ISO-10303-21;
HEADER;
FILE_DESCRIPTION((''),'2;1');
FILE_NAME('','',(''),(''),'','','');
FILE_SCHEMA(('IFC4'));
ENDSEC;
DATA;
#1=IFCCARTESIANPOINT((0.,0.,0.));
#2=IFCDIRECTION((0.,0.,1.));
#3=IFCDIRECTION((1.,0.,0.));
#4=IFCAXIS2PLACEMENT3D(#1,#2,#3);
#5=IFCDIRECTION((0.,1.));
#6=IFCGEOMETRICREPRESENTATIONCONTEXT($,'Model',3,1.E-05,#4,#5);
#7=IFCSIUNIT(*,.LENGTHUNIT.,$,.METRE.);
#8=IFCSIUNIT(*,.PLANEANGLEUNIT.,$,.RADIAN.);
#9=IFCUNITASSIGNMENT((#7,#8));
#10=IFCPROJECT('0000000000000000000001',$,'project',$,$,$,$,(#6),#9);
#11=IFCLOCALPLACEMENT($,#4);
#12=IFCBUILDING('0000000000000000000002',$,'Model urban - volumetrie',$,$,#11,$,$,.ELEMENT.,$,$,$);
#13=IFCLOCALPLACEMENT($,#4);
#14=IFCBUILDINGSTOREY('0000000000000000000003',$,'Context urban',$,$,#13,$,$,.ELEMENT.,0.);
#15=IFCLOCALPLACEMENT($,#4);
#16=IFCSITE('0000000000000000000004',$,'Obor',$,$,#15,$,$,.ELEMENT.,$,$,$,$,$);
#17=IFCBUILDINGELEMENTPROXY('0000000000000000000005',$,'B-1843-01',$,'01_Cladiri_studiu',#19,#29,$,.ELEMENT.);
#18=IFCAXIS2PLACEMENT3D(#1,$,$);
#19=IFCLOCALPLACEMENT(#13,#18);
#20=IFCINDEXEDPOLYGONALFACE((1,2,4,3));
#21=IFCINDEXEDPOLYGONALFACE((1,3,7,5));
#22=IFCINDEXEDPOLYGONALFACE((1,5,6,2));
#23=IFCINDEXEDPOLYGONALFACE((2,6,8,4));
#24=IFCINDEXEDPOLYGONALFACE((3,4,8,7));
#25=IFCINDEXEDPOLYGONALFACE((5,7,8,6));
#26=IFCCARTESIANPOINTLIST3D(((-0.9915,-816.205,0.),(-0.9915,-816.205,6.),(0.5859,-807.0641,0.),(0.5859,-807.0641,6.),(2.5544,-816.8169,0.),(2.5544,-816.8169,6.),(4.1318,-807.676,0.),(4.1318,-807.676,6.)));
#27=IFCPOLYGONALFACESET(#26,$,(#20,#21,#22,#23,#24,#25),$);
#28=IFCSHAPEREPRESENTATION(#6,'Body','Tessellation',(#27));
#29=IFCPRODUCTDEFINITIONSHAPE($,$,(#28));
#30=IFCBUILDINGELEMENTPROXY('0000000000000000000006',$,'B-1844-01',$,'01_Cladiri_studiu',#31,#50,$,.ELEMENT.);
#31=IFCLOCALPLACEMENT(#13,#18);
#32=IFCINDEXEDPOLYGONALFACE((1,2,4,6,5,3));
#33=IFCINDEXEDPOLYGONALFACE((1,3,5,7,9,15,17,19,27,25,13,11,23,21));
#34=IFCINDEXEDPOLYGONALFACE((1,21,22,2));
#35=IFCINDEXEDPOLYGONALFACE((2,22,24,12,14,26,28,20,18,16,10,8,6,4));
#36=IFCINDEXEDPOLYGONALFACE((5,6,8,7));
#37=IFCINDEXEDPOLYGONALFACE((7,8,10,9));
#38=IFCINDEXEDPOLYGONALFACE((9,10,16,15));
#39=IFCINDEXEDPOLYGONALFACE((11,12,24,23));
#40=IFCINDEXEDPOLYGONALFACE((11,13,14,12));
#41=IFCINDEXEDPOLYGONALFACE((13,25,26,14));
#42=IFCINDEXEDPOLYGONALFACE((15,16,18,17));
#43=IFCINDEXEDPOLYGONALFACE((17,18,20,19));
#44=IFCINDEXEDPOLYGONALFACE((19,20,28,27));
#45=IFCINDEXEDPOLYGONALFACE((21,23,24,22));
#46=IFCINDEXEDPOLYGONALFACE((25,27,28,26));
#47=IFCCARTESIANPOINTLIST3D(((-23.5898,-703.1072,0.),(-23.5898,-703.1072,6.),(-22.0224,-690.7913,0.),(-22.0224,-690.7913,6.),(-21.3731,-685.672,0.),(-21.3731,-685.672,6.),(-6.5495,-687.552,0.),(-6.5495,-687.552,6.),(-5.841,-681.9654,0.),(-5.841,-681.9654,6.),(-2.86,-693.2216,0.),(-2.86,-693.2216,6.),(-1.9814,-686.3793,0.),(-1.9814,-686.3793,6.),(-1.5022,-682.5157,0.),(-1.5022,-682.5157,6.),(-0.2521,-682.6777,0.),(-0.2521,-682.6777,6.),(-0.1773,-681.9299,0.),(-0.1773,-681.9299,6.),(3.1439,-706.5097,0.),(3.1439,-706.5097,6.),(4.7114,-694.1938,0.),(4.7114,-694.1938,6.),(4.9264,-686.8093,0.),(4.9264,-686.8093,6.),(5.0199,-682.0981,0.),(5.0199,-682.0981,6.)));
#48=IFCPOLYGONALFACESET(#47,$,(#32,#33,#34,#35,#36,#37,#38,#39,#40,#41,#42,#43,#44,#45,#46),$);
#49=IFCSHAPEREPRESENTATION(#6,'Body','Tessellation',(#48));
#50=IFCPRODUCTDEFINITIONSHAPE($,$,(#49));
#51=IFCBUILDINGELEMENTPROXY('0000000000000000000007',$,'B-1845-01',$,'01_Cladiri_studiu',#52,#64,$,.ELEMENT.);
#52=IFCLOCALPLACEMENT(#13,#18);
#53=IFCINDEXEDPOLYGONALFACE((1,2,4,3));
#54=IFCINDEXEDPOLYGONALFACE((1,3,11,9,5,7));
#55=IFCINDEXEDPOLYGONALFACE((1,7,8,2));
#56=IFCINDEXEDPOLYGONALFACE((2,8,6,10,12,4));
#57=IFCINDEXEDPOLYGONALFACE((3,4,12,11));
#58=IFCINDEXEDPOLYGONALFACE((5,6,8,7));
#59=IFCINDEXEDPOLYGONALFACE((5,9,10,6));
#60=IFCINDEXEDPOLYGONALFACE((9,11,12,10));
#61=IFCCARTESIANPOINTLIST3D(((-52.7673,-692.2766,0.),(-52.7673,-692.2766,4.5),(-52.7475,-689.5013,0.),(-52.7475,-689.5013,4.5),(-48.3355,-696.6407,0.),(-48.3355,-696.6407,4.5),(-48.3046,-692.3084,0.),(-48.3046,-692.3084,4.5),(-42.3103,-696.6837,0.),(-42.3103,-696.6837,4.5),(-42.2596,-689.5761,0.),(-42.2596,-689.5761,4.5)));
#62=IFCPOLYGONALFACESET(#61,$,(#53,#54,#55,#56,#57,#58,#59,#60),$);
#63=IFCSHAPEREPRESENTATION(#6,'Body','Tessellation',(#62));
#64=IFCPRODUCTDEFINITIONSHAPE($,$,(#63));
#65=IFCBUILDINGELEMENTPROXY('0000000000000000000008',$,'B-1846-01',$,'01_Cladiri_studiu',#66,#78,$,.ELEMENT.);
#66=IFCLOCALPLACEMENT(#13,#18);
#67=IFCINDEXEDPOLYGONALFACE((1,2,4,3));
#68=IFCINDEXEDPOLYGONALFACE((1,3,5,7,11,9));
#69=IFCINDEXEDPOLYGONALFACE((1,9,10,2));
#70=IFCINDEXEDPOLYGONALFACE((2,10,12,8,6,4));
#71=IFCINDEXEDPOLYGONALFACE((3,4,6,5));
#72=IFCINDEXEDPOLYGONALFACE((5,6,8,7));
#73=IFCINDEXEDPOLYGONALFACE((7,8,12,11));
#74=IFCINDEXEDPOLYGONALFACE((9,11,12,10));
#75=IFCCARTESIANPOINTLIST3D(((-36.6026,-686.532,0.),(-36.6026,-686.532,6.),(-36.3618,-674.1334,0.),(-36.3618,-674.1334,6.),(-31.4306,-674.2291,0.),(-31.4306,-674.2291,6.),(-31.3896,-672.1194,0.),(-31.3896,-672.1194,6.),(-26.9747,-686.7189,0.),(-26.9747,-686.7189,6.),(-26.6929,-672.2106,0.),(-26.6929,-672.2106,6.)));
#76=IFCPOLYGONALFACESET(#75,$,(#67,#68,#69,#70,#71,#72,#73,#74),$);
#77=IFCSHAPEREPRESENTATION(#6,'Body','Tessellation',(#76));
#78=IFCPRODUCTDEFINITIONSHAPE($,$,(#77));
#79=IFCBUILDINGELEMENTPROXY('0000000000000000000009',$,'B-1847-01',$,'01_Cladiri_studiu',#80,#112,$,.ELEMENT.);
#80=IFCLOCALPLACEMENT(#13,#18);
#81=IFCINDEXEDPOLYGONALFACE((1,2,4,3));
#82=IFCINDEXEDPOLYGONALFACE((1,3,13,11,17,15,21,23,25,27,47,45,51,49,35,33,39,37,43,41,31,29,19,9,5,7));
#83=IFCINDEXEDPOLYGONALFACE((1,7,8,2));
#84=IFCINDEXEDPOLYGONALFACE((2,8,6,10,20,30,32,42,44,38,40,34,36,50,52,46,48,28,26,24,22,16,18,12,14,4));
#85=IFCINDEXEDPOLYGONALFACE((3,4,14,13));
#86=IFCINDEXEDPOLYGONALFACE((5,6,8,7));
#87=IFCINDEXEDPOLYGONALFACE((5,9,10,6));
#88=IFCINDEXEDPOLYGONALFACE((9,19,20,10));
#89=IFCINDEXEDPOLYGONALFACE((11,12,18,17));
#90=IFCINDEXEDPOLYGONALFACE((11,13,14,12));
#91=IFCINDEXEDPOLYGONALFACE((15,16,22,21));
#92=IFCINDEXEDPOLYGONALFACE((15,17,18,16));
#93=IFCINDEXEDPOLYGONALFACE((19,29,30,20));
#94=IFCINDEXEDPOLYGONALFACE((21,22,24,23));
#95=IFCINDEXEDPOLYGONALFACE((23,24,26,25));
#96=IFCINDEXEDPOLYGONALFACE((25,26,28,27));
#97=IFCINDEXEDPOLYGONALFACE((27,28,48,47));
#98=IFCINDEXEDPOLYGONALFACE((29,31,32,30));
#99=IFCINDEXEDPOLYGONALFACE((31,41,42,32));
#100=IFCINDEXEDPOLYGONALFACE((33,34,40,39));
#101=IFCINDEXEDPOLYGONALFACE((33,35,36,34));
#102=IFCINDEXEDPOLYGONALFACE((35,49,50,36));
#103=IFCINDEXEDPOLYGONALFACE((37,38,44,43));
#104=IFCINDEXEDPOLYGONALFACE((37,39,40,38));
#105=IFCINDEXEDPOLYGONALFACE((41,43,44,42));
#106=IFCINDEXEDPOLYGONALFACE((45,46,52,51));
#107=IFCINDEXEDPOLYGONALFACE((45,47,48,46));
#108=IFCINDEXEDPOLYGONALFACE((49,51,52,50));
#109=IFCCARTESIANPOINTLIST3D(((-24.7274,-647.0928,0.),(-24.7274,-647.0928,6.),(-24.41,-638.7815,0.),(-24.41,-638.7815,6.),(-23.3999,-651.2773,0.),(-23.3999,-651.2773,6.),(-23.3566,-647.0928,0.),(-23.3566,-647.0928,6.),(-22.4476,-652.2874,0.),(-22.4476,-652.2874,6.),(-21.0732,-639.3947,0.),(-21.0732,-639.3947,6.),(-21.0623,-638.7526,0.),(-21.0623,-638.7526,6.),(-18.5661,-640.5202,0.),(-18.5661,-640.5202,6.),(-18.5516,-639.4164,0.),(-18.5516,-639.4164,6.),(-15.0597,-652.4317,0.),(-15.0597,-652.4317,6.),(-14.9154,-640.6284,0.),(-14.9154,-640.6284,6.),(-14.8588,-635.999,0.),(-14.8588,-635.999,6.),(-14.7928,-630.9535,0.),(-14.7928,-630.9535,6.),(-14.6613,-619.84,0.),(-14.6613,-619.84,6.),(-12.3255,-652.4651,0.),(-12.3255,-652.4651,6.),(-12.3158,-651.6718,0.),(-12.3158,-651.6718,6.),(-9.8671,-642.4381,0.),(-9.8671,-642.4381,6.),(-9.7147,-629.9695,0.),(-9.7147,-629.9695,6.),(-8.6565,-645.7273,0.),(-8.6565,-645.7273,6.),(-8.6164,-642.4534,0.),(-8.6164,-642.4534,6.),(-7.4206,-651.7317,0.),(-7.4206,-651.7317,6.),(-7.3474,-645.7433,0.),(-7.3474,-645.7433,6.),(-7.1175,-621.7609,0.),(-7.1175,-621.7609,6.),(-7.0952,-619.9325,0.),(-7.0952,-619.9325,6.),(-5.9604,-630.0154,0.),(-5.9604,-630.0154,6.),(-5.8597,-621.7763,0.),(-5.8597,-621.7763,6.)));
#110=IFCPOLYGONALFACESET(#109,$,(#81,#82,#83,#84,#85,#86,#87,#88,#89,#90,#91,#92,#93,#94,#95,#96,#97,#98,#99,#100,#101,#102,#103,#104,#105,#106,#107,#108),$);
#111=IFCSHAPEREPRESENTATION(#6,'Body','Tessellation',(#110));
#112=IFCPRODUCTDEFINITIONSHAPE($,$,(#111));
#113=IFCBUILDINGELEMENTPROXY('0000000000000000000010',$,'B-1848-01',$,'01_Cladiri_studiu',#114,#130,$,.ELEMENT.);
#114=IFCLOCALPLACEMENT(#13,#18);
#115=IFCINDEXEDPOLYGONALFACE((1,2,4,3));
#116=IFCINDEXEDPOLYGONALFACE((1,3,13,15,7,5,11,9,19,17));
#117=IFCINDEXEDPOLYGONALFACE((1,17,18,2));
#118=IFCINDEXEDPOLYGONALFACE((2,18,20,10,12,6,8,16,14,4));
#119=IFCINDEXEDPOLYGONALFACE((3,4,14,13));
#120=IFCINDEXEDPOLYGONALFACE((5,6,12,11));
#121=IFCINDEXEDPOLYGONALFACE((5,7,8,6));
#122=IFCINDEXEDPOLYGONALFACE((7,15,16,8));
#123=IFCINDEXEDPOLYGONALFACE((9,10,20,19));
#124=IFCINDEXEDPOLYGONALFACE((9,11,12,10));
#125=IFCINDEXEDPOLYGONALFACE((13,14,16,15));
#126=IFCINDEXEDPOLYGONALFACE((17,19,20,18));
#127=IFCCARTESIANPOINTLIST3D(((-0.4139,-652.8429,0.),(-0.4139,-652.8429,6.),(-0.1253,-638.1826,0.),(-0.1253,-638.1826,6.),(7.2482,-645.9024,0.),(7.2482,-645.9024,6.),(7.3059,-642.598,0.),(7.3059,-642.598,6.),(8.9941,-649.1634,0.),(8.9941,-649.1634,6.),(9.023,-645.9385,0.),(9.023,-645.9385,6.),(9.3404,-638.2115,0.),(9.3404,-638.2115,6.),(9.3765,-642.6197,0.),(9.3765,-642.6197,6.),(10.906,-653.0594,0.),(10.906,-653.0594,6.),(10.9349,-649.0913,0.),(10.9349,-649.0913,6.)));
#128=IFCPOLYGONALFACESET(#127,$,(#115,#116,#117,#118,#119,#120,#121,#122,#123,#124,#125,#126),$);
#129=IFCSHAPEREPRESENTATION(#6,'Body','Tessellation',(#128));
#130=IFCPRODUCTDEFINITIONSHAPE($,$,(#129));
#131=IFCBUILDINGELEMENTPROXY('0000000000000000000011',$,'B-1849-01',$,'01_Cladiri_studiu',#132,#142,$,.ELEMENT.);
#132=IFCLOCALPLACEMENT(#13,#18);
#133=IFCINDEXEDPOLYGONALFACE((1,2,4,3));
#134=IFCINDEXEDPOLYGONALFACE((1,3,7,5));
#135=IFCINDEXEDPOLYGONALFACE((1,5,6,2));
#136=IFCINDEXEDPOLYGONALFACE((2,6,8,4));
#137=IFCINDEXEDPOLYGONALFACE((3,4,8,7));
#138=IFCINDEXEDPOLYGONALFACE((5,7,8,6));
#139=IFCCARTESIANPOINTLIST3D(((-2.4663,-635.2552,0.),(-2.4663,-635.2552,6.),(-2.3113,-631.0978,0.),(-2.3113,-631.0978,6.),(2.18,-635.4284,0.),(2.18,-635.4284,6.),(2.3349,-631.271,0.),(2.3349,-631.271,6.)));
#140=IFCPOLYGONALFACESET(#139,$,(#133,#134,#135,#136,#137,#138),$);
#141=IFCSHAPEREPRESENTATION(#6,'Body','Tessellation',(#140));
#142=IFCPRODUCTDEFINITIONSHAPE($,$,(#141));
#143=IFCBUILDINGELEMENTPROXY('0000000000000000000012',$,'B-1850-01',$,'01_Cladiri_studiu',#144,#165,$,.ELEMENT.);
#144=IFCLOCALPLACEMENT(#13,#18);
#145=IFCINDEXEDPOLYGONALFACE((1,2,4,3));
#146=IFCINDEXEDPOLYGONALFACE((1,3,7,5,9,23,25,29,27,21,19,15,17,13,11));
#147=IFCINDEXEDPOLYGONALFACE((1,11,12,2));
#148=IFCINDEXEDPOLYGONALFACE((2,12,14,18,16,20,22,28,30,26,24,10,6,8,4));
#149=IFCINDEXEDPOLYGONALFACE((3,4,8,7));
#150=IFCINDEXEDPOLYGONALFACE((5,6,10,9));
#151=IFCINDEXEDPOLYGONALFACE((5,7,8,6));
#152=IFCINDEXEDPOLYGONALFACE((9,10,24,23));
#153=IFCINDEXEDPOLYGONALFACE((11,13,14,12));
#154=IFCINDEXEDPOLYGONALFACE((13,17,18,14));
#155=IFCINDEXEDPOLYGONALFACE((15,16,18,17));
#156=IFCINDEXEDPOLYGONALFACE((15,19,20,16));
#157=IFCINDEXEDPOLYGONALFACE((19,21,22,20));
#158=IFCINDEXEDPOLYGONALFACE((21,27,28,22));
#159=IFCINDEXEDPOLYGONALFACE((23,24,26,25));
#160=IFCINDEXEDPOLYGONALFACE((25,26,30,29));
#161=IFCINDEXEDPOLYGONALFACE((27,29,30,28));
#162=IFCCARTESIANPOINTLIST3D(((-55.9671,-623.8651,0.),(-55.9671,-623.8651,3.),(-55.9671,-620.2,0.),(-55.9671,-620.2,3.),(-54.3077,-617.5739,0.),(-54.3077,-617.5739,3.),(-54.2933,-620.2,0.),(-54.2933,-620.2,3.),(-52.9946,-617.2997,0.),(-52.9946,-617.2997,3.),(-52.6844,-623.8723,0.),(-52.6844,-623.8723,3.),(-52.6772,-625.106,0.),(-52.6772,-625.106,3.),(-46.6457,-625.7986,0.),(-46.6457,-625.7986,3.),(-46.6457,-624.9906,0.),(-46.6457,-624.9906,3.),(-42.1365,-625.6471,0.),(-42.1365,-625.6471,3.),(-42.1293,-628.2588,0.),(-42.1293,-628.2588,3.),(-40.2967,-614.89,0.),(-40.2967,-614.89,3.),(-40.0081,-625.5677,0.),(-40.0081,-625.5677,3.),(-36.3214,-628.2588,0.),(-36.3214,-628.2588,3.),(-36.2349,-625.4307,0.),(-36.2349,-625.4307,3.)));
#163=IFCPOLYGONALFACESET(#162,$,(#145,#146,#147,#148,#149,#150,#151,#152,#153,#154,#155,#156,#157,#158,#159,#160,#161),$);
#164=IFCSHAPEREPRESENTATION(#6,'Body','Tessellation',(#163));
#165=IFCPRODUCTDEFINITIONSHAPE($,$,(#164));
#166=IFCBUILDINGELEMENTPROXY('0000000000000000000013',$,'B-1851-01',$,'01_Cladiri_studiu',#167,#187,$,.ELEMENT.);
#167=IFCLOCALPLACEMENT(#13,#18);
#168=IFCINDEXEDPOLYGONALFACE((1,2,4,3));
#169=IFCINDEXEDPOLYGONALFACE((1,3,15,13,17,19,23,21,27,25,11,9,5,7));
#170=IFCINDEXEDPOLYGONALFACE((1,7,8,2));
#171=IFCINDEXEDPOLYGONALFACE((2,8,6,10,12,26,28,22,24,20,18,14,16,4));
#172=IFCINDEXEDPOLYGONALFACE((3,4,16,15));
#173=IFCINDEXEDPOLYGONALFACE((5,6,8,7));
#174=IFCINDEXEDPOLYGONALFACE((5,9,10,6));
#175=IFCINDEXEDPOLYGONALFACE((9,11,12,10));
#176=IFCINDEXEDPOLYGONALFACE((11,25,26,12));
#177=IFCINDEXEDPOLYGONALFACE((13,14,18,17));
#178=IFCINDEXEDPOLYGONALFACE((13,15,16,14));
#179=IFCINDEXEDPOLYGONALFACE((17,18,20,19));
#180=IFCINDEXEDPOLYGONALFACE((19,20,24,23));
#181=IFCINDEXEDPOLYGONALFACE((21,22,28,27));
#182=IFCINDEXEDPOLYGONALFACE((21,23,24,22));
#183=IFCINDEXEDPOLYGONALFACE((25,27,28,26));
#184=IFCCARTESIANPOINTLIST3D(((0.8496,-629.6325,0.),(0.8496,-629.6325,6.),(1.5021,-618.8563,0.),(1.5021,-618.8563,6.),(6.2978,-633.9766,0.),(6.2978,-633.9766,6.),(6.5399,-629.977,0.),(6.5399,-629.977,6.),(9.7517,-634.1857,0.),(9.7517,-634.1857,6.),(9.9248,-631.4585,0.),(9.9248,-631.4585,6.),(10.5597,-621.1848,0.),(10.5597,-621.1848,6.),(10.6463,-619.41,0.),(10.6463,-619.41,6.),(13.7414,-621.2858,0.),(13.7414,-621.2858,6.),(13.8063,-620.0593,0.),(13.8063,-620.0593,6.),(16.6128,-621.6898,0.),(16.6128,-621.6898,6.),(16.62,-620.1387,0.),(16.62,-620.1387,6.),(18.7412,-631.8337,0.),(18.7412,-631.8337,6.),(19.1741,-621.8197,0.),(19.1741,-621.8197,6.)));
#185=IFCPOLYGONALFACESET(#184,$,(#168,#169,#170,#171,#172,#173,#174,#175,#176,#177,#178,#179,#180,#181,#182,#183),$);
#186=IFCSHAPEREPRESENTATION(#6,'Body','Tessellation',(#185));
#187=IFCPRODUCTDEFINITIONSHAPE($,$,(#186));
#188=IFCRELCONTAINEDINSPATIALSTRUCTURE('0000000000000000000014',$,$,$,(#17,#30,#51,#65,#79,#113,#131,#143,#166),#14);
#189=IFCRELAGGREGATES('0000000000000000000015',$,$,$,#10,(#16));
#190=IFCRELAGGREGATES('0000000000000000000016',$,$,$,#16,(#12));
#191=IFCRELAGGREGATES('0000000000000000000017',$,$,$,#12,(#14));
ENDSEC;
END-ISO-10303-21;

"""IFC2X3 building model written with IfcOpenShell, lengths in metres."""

from ifc_helpers import new_model, si_unit, direction, origin_with_axes, place, context, project, spatial, polyline, outline, extrude, element, save


model = new_model("IFC2X3")

# Units and contexts
model_context = context("Model", 3, precision=1e-05, world=origin_with_axes(), true_north=direction((0.0, 1.0)))
ifc_project = project(units=[si_unit("LENGTHUNIT", "METRE"), si_unit("PLANEANGLEUNIT", "RADIAN")], contexts=[model_context])

# Site, building, storey
site_placement = place(None, origin_with_axes())
site = spatial("IfcSite", under=ifc_project, at=site_placement, Name="Obor", CompositionType="ELEMENT")
building_placement = place(None, origin_with_axes())
building = spatial("IfcBuilding", under=site, at=building_placement, Name="Model urban - volumetrie", CompositionType="ELEMENT")
storey_placement = place(None, origin_with_axes())
storey = spatial("IfcBuildingStorey", under=building, at=storey_placement, Name="Context urban", CompositionType="ELEMENT", Elevation=0.0)

# Building element proxies
proxy_1_placement = place(None, origin_with_axes())
element("IfcBuildingElementProxy", 1, at=proxy_1_placement, inside=storey, Name="B-1843-01", ObjectType="01_Cladiri_studiu", CompositionType="ELEMENT", context=model_context, shape_type="SweptSolid", body=[
    extrude(outline(polyline([(-0.9915, -816.205), (2.5544, -816.8169), (4.1318, -807.676), (0.5859, -807.0641), (-0.9915, -816.205)])), origin_with_axes(), (0.0, 0.0, 1.0), 6.0),
])
proxy_2_placement = place(None, origin_with_axes())
element("IfcBuildingElementProxy", 2, at=proxy_2_placement, inside=storey, Name="B-1844-01", ObjectType="01_Cladiri_studiu", CompositionType="ELEMENT", context=model_context, shape_type="SweptSolid", body=[
    extrude(outline(polyline([(-0.2521, -682.6777), (-1.5022, -682.5157), (-5.841, -681.9654), (-6.5495, -687.552), (-21.3731, -685.672), (-22.0224, -690.7913), (-23.5898, -703.1072), (3.1439, -706.5097), (4.7114, -694.1938), (-2.86, -693.2216), (-1.9814, -686.3793), (4.9264, -686.8093), (5.0199, -682.0981), (-0.1773, -681.9299), (-0.2521, -682.6777)])), origin_with_axes(), (0.0, 0.0, 1.0), 6.0),
])
proxy_3_placement = place(None, origin_with_axes())
element("IfcBuildingElementProxy", 3, at=proxy_3_placement, inside=storey, Name="B-1845-01", ObjectType="01_Cladiri_studiu", CompositionType="ELEMENT", context=model_context, shape_type="SweptSolid", body=[
    extrude(outline(polyline([(-42.3103, -696.6837), (-42.2596, -689.5761), (-52.7475, -689.5013), (-52.7673, -692.2766), (-48.3046, -692.3084), (-48.3355, -696.6407), (-42.3103, -696.6837)])), origin_with_axes(), (0.0, 0.0, 1.0), 4.5),
])
proxy_4_placement = place(None, origin_with_axes())
element("IfcBuildingElementProxy", 4, at=proxy_4_placement, inside=storey, Name="B-1846-01", ObjectType="01_Cladiri_studiu", CompositionType="ELEMENT", context=model_context, shape_type="SweptSolid", body=[
    extrude(outline(polyline([(-31.4306, -674.2291), (-36.3618, -674.1334), (-36.6026, -686.532), (-26.9747, -686.7189), (-26.6929, -672.2106), (-31.3896, -672.1194), (-31.4306, -674.2291)])), origin_with_axes(), (0.0, 0.0, 1.0), 6.0),
])
proxy_5_placement = place(None, origin_with_axes())
element("IfcBuildingElementProxy", 5, at=proxy_5_placement, inside=storey, Name="B-1847-01", ObjectType="01_Cladiri_studiu", CompositionType="ELEMENT", context=model_context, shape_type="SweptSolid", body=[
    extrude(outline(polyline([(-24.7274, -647.0928), (-23.3566, -647.0928), (-23.3999, -651.2773), (-22.4476, -652.2874), (-15.0597, -652.4317), (-12.3255, -652.4651), (-12.3158, -651.6718), (-7.4206, -651.7317), (-7.3474, -645.7433), (-8.6565, -645.7273), (-8.6164, -642.4534), (-9.8671, -642.4381), (-9.7147, -629.9695), (-5.9604, -630.0154), (-5.8597, -621.7763), (-7.1175, -621.7609), (-7.0952, -619.9325), (-14.6613, -619.84), (-14.7928, -630.9535), (-14.8588, -635.999), (-14.9154, -640.6284), (-18.5661, -640.5202), (-18.5516, -639.4164), (-21.0732, -639.3947), (-21.0623, -638.7526), (-24.41, -638.7815), (-24.7274, -647.0928)])), origin_with_axes(), (0.0, 0.0, 1.0), 6.0),
])
proxy_6_placement = place(None, origin_with_axes())
element("IfcBuildingElementProxy", 6, at=proxy_6_placement, inside=storey, Name="B-1848-01", ObjectType="01_Cladiri_studiu", CompositionType="ELEMENT", context=model_context, shape_type="SweptSolid", body=[
    extrude(outline(polyline([(9.3765, -642.6197), (9.3404, -638.2115), (-0.1253, -638.1826), (-0.4139, -652.8429), (10.906, -653.0594), (10.9349, -649.0913), (8.9941, -649.1634), (9.023, -645.9385), (7.2482, -645.9024), (7.3059, -642.598), (9.3765, -642.6197)])), origin_with_axes(), (0.0, 0.0, 1.0), 6.0),
])
proxy_7_placement = place(None, origin_with_axes())
element("IfcBuildingElementProxy", 7, at=proxy_7_placement, inside=storey, Name="B-1849-01", ObjectType="01_Cladiri_studiu", CompositionType="ELEMENT", context=model_context, shape_type="SweptSolid", body=[
    extrude(outline(polyline([(2.18, -635.4284), (2.3349, -631.271), (-2.3113, -631.0978), (-2.4663, -635.2552), (2.18, -635.4284)])), origin_with_axes(), (0.0, 0.0, 1.0), 6.0),
])
proxy_8_placement = place(None, origin_with_axes())
element("IfcBuildingElementProxy", 8, at=proxy_8_placement, inside=storey, Name="B-1850-01", ObjectType="01_Cladiri_studiu", CompositionType="ELEMENT", context=model_context, shape_type="SweptSolid", body=[
    extrude(outline(polyline([(-40.2967, -614.89), (-52.9946, -617.2997), (-54.3077, -617.5739), (-54.2933, -620.2), (-55.9671, -620.2), (-55.9671, -623.8651), (-52.6844, -623.8723), (-52.6772, -625.106), (-46.6457, -624.9906), (-46.6457, -625.7986), (-42.1365, -625.6471), (-42.1293, -628.2588), (-36.3214, -628.2588), (-36.2349, -625.4307), (-40.0081, -625.5677), (-40.2967, -614.89)])), origin_with_axes(), (0.0, 0.0, 1.0), 3.0),
])
proxy_9_placement = place(None, origin_with_axes())
element("IfcBuildingElementProxy", 9, at=proxy_9_placement, inside=storey, Name="B-1851-01", ObjectType="01_Cladiri_studiu", CompositionType="ELEMENT", context=model_context, shape_type="SweptSolid", body=[
    extrude(outline(polyline([(10.6463, -619.41), (1.5021, -618.8563), (0.8496, -629.6325), (6.5399, -629.977), (6.2978, -633.9766), (9.7517, -634.1857), (9.9248, -631.4585), (18.7412, -631.8337), (19.1741, -621.8197), (16.6128, -621.6898), (16.62, -620.1387), (13.8063, -620.0593), (13.7414, -621.2858), (10.5597, -621.1848), (10.6463, -619.41)])), origin_with_axes(), (0.0, 0.0, 1.0), 6.0),
])

save(model, "model.ifc")
